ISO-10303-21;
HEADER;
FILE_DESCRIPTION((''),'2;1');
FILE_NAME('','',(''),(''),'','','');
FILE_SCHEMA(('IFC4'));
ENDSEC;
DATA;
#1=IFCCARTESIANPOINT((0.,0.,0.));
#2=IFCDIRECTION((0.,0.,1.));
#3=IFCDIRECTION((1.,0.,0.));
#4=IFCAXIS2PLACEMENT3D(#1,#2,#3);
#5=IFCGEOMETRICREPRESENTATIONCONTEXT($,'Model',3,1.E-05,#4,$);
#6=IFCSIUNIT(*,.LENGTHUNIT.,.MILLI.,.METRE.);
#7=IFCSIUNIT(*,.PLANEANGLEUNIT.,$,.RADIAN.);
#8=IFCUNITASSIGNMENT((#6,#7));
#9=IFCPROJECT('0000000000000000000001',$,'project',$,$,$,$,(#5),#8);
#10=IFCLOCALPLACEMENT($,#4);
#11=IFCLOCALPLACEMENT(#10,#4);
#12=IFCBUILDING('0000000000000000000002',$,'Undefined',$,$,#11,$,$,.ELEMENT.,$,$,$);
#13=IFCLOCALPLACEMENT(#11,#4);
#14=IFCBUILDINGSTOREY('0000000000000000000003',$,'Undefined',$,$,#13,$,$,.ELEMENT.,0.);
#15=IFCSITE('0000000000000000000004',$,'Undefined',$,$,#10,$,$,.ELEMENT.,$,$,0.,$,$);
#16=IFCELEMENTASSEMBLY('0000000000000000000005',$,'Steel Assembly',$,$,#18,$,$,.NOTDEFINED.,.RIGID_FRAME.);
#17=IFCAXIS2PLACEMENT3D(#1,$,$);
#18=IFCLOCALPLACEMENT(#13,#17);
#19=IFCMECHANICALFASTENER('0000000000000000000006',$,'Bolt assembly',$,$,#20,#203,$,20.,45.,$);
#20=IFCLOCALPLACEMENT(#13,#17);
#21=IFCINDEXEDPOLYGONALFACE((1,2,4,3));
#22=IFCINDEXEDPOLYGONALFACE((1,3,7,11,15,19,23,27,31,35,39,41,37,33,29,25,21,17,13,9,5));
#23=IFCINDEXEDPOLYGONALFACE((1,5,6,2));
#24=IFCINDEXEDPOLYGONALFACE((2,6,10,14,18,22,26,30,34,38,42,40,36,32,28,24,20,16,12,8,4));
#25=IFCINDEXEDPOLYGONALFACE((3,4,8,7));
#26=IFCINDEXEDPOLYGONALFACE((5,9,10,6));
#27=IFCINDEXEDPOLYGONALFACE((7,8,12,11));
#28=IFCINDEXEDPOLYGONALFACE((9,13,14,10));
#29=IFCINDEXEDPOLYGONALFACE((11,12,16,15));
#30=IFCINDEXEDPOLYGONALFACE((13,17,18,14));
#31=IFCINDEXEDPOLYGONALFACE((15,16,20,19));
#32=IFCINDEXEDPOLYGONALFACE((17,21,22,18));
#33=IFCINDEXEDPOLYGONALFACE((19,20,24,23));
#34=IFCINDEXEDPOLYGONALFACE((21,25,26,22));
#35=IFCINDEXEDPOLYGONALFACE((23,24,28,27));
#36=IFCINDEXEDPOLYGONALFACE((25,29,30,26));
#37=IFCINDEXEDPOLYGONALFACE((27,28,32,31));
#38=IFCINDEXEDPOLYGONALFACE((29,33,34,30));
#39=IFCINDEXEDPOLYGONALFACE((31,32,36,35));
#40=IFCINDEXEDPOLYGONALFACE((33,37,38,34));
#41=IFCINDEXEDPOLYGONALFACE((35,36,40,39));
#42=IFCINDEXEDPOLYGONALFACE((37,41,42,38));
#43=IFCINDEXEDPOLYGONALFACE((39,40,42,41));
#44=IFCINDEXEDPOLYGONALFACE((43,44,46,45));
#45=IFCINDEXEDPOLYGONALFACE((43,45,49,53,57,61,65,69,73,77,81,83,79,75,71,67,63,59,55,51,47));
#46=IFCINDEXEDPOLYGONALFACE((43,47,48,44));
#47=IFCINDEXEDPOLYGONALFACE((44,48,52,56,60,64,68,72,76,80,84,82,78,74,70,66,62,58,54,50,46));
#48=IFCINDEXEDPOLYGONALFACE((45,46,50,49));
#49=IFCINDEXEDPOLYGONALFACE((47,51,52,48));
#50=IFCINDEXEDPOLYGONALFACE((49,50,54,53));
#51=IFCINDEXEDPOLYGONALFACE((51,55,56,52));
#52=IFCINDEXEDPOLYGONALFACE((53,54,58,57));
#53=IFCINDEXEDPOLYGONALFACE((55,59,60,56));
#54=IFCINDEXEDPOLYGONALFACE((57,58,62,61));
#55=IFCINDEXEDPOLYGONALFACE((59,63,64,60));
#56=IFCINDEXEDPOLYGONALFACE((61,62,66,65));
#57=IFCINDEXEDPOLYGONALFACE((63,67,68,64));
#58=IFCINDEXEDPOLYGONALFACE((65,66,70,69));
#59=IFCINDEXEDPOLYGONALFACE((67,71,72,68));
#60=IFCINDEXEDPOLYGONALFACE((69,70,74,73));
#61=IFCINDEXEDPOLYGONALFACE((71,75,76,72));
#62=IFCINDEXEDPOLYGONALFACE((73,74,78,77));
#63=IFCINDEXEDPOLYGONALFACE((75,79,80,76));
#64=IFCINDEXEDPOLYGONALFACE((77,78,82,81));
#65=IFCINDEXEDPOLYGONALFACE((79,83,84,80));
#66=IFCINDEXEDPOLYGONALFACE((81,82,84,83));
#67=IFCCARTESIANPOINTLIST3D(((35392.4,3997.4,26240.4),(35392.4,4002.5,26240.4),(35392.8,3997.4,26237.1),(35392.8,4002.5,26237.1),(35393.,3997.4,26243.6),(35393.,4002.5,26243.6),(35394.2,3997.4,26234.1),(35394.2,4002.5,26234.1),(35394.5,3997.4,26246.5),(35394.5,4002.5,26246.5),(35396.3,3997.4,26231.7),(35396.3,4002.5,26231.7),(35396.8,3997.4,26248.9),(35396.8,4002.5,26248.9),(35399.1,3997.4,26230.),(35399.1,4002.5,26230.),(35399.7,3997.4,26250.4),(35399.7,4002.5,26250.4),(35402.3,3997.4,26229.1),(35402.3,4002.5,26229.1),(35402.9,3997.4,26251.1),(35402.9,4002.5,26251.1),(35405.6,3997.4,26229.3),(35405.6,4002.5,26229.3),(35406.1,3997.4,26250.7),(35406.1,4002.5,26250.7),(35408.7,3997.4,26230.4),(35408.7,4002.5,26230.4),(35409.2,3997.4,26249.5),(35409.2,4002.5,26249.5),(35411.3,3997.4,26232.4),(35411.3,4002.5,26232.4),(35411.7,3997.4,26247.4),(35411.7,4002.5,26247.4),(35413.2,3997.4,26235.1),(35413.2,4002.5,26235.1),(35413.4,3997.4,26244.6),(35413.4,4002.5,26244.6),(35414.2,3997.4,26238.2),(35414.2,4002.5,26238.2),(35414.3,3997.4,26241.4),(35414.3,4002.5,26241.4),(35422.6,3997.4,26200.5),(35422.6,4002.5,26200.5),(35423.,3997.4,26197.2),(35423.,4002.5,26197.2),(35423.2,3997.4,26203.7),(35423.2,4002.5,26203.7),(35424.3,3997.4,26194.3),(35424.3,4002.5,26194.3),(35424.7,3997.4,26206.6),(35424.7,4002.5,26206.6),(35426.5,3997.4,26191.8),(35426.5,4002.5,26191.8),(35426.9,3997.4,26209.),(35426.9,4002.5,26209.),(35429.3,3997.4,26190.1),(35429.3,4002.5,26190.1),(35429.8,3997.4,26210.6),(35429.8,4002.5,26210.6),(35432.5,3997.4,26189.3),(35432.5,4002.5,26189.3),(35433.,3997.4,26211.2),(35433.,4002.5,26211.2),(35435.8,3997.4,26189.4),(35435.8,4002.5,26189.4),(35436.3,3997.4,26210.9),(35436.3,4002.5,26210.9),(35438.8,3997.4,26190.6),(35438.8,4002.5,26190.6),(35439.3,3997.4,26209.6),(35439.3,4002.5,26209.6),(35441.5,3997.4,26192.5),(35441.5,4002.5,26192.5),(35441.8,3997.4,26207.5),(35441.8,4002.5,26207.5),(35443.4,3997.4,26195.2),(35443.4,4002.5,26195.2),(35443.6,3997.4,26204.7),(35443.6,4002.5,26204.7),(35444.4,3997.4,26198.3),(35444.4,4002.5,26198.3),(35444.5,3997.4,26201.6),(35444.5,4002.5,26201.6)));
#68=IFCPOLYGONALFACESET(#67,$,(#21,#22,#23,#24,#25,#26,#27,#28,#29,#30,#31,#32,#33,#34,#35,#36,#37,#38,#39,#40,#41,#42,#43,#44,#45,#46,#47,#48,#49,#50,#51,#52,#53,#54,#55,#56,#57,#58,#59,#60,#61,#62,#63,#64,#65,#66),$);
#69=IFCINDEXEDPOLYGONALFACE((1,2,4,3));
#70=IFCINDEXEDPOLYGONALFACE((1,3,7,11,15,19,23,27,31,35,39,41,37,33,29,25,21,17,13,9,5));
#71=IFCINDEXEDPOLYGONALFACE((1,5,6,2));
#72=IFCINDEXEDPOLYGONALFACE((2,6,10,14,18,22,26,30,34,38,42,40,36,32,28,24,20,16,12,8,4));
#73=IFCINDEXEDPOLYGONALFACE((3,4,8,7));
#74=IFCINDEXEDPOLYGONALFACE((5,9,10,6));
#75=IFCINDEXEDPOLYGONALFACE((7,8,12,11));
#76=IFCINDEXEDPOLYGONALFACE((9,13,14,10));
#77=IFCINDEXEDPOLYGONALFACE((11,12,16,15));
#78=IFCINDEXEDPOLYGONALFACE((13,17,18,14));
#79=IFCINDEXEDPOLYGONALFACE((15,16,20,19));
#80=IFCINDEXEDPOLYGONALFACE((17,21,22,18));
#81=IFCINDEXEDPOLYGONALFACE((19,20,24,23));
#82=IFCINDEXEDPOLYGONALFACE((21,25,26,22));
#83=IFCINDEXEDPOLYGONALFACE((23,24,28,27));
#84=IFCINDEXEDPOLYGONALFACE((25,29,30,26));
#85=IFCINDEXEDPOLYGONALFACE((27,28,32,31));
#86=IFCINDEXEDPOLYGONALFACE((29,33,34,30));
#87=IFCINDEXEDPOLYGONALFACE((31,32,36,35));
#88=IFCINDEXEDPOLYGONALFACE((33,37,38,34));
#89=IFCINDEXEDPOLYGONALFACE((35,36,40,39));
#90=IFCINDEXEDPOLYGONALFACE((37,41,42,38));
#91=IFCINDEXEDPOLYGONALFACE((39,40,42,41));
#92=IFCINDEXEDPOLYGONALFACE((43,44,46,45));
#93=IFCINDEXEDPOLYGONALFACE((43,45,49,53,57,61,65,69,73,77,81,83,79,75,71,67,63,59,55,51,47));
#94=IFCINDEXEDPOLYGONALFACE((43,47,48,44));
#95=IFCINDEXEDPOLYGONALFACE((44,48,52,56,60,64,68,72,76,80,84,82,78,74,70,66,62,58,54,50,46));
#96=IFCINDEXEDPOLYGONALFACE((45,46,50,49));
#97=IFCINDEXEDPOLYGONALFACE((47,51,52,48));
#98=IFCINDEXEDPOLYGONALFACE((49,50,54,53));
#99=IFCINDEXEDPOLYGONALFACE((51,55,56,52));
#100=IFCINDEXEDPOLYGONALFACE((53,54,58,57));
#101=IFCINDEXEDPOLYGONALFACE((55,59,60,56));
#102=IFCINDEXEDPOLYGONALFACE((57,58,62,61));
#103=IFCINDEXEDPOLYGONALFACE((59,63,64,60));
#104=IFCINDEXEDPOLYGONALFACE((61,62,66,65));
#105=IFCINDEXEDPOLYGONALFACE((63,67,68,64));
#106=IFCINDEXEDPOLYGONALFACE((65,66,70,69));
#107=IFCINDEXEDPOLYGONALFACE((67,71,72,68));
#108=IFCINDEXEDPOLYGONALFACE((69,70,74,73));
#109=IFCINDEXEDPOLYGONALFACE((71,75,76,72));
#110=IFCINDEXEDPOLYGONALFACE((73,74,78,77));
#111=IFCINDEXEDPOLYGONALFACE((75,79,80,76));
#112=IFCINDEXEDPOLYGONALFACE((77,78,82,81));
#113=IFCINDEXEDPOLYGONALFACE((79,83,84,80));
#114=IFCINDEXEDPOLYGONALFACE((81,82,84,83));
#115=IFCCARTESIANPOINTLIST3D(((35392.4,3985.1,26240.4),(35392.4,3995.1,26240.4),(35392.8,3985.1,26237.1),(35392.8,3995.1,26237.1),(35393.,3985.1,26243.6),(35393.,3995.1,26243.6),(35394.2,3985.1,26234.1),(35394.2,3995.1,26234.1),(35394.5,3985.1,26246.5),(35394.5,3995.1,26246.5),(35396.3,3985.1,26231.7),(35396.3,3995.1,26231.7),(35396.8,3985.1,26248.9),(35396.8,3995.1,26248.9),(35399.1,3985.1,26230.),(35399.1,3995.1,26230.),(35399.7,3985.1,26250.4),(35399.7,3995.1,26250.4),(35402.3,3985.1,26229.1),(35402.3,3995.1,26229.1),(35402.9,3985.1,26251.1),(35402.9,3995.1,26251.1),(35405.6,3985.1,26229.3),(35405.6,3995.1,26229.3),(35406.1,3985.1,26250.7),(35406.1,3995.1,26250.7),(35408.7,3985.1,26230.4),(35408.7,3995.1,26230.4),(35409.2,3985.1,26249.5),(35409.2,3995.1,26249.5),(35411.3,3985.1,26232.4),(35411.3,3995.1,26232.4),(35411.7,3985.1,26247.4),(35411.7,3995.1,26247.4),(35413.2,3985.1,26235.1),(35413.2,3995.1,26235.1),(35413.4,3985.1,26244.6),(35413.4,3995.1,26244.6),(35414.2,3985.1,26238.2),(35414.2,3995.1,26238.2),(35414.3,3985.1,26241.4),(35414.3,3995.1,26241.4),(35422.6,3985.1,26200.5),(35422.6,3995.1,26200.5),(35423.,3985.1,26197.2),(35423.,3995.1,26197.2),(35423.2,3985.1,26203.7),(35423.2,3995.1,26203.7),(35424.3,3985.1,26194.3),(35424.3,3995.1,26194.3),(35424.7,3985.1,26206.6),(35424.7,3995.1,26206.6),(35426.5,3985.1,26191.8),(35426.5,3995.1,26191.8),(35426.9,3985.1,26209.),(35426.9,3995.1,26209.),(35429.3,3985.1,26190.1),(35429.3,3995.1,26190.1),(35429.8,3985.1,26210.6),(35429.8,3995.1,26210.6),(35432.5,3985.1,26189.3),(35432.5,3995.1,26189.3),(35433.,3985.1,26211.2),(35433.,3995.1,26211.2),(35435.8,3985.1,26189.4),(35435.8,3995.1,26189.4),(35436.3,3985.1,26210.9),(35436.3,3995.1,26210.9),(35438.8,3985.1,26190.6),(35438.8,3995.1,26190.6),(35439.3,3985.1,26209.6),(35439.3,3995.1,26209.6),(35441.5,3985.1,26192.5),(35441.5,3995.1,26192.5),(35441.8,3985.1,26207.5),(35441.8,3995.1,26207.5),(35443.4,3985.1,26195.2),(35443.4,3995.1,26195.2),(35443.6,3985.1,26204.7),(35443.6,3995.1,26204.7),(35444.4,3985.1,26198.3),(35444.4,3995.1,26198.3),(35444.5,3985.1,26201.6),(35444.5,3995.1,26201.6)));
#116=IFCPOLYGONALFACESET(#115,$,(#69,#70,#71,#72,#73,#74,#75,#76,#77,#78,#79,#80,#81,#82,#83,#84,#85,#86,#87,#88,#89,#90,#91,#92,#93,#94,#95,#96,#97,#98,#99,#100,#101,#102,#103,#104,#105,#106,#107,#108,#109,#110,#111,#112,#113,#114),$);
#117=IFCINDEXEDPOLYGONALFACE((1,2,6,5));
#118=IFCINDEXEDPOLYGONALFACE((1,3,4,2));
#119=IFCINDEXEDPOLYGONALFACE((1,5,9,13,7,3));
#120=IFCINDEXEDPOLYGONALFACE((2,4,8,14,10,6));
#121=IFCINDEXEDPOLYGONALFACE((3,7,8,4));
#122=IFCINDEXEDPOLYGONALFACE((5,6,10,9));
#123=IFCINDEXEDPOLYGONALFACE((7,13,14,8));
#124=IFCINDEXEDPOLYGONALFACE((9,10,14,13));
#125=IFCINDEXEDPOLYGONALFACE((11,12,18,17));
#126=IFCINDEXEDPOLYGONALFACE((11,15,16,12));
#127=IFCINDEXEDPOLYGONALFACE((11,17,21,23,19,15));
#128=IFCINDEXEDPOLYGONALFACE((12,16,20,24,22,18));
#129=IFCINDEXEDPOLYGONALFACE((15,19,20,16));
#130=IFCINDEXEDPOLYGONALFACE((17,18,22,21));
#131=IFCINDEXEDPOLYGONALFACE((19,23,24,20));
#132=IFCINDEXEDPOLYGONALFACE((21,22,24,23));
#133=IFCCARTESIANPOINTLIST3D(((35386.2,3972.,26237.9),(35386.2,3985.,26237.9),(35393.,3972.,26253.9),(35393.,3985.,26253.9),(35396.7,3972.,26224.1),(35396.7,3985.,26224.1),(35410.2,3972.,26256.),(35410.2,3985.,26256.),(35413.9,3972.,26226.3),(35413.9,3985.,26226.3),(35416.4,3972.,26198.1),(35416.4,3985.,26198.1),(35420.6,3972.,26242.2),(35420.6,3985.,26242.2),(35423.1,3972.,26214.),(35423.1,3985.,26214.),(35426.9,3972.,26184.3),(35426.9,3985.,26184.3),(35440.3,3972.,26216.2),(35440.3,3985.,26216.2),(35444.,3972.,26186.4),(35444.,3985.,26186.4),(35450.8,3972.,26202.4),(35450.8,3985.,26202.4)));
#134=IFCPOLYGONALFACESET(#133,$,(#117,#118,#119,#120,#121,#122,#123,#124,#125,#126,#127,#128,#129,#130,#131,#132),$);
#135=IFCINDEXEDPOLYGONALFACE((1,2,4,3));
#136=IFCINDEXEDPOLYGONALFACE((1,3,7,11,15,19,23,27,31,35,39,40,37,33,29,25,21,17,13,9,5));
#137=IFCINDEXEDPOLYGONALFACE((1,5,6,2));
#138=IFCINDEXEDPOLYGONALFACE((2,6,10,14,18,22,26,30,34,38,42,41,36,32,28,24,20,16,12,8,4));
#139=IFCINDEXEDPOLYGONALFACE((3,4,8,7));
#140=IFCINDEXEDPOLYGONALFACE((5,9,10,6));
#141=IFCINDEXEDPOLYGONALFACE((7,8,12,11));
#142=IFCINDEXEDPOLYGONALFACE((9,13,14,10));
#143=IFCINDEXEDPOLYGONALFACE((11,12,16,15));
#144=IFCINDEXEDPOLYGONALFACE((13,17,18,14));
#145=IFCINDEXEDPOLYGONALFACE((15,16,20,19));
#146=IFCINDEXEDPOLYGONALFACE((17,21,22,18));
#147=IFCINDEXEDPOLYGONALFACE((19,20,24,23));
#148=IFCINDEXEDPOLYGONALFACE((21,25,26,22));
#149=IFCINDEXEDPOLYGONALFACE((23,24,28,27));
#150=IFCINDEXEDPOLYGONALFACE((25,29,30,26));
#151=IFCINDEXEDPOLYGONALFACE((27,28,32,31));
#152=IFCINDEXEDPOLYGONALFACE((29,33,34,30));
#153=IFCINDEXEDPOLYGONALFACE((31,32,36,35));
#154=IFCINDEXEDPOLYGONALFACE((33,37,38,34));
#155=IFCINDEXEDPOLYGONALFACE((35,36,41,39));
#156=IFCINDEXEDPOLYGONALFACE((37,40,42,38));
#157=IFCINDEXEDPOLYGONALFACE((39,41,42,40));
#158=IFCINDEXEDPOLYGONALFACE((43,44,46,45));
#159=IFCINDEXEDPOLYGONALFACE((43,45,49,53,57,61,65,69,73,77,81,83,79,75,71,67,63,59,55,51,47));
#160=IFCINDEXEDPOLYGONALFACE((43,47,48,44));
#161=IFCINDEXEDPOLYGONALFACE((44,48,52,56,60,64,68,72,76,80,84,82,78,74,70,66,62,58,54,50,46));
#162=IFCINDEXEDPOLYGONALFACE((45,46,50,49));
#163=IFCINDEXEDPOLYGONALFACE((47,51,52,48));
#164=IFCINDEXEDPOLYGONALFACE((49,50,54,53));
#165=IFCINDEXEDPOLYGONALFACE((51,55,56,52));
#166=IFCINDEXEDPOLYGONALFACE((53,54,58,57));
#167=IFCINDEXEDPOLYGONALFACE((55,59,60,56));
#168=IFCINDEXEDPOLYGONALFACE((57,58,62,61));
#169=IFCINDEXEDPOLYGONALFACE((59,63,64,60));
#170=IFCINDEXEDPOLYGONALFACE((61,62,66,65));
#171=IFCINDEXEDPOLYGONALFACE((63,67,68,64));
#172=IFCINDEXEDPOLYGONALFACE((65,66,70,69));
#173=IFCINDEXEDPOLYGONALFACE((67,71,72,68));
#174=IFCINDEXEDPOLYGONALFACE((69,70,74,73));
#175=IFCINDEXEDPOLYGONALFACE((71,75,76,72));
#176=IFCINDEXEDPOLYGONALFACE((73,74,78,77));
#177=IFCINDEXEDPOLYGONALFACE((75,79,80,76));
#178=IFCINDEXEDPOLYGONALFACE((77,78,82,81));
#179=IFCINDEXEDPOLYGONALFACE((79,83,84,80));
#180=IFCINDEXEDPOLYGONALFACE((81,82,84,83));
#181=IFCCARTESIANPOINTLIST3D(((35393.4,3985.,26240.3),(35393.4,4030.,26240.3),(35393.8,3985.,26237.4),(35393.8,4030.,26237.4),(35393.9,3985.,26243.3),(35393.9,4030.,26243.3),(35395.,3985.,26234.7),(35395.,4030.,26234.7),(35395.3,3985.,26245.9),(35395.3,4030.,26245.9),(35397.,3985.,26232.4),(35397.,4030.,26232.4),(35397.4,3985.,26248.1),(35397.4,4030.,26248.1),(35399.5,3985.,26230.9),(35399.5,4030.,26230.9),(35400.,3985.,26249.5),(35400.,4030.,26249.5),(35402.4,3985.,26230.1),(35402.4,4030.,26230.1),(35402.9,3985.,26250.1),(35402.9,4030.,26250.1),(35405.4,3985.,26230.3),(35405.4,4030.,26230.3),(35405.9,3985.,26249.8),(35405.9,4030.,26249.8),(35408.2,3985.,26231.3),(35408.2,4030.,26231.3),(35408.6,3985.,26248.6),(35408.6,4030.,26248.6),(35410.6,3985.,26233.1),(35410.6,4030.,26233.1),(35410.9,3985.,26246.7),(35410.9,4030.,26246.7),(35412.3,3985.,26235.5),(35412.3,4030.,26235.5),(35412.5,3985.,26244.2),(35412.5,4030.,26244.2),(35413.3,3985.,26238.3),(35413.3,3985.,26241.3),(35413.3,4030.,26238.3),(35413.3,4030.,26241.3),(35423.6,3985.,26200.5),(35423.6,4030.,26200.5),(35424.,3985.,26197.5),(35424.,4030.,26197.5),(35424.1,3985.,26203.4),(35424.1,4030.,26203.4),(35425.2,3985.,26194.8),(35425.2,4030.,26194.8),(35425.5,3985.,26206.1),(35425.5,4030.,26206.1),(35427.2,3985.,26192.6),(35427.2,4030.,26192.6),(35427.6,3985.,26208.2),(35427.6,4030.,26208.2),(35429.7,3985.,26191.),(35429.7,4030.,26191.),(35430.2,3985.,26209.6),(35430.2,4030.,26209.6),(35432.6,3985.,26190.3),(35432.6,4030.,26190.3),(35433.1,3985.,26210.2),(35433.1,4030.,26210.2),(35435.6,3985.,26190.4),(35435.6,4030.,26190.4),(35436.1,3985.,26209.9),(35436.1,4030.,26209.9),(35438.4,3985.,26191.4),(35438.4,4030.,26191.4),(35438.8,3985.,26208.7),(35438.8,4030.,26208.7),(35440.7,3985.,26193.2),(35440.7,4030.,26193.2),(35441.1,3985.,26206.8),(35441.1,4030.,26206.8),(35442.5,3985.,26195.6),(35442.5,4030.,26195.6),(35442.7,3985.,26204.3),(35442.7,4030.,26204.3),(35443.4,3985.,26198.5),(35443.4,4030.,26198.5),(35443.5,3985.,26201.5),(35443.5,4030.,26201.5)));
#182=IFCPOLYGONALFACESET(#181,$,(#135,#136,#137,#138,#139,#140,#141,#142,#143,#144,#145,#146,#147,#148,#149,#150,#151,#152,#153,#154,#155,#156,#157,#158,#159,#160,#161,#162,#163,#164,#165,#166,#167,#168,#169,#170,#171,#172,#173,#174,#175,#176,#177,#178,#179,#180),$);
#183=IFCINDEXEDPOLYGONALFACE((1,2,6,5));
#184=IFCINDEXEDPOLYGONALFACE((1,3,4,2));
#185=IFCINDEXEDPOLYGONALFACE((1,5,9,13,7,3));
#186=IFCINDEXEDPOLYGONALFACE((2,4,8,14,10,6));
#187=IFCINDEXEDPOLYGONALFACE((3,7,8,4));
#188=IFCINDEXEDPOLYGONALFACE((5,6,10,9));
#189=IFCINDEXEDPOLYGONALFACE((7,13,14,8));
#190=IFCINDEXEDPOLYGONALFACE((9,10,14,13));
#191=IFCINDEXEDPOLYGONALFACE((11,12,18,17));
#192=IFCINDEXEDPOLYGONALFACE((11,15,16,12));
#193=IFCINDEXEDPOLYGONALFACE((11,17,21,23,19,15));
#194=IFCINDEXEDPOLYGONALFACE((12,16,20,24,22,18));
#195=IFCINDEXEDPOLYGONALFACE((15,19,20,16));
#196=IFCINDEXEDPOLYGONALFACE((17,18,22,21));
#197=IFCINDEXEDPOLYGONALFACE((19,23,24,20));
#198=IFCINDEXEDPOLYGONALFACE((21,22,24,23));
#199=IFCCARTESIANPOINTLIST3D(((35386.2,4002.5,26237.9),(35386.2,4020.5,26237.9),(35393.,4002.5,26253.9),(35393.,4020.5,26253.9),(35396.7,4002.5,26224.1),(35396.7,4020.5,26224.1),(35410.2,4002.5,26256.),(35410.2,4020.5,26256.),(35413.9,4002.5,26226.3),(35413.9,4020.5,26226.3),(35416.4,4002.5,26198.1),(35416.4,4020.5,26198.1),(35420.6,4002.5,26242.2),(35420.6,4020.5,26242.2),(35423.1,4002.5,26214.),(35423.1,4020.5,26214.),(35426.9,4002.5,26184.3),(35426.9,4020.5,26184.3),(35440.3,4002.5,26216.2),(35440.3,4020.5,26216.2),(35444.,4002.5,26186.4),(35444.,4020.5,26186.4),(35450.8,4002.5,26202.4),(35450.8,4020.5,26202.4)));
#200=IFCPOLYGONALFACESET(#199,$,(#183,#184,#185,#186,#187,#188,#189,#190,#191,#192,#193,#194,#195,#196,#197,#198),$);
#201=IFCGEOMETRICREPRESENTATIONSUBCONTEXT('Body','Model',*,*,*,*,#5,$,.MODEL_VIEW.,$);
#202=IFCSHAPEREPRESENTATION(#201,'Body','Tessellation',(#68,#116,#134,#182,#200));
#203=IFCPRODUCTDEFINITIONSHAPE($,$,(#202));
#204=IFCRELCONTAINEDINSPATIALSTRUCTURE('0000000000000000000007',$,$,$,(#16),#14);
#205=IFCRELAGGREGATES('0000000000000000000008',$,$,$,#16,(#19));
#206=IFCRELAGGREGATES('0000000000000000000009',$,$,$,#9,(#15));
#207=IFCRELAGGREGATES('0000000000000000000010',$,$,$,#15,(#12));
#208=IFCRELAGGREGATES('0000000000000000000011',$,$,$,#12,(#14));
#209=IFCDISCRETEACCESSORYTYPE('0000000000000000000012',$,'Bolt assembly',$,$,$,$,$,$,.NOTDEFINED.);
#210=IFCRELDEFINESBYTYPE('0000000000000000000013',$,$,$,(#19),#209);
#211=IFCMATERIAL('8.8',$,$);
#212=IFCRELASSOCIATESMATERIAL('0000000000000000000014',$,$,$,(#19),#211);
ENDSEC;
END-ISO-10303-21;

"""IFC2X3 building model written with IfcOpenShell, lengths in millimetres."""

from ifc_helpers import new_model, si_unit, frame, origin_with_axes, origin_2d_with_axis, place, context, subcontext, project, spatial, polyline, circle, outline, extrude, source, transform, mapped, material, type_object, element, aggregate, save


model = new_model("IFC2X3")

# Units and contexts
model_context = context("Model", 3, precision=1e-05, world=origin_with_axes())
body_context = subcontext(model_context, "Body", "Model", "MODEL_VIEW")
ifc_project = project(units=[si_unit("LENGTHUNIT", "METRE", prefix="MILLI"), si_unit("PLANEANGLEUNIT", "RADIAN")], contexts=[model_context])

# Site, building, storey
site_placement = place(None, origin_with_axes())
site = spatial("IfcSite", under=ifc_project, at=site_placement, Name="Undefined", CompositionType="ELEMENT", RefElevation=0.0)
building_placement = place(site_placement, origin_with_axes())
building = spatial("IfcBuilding", under=site, at=building_placement, Name="Undefined", CompositionType="ELEMENT")
storey_placement = place(building_placement, origin_with_axes())
storey = spatial("IfcBuildingStorey", under=building, at=storey_placement, Name="Undefined", CompositionType="ELEMENT", Elevation=0.0)

# Element assembly
assembly_1_placement = place(storey_placement, origin_with_axes())
assembly_1 = element("IfcElementAssembly", 1, at=assembly_1_placement, inside=storey, Name="Steel Assembly", AssemblyPlace="NOTDEFINED", PredefinedType="RIGID_FRAME")

# Shared definitions
discrete_accessory_type_1 = type_object("IfcDiscreteAccessoryType", Name="Bolt assembly")
ifc_material_1 = material(Name="8.8")

# Mechanical fastener
shared_shape_1 = source(origin_with_axes(), body_context, "Body", "SweptSolid", [
    extrude(circle(Radius=11.0, at=origin_2d_with_axis()), frame((0.0, -2.6, 0.0), z_axis=(0.0, 1.0, 0.0), x_axis=(1.0, 0.0, 0.0)), (0.0, 0.0, 1.0), 5.1),
    extrude(circle(Radius=11.0, at=origin_2d_with_axis()), frame((0.0, -14.9, 0.0), z_axis=(0.0, 1.0, 0.0), x_axis=(1.0, 0.0, 0.0)), (0.0, 0.0, 1.0), 10.0),
    extrude(outline(polyline([(17.3, 0.0), (8.7, 15.0), (-8.7, 15.0), (-17.3, 0.0), (-8.7, -15.0), (8.7, -15.0), (17.3, 0.0)])), frame((0.0, -28.0, 0.0), z_axis=(0.0, 1.0, 0.0), x_axis=(1.0, 0.0, 0.0)), (0.0, 0.0, 1.0), 13.0),
    extrude(circle(Radius=10.0, at=origin_2d_with_axis()), frame((0.0, -15.0, 0.0), z_axis=(0.0, 1.0, 0.0), x_axis=(1.0, 0.0, 0.0)), (0.0, 0.0, 1.0), 45.0),
    extrude(outline(polyline([(17.3, 0.0), (8.7, 15.0), (-8.7, 15.0), (-17.3, 0.0), (-8.7, -15.0), (8.7, -15.0), (17.3, 0.0)])), frame((0.0, 2.5, 0.0), z_axis=(0.0, 1.0, 0.0), x_axis=(1.0, 0.0, 0.0)), (0.0, 0.0, 1.0), 18.0),
])
mechanical_fastener_1_placement = place(assembly_1_placement, frame((35433.6, 4000.0, 26200.2), z_axis=(-0.797403, 0.0, -0.603447), x_axis=(-0.603447, 0.0, 0.797403)))
mechanical_fastener_1 = element("IfcMechanicalFastener", 2, at=mechanical_fastener_1_placement, type_object=discrete_accessory_type_1, material=ifc_material_1, Name="Bolt assembly", NominalDiameter=20.0, NominalLength=45.0, context=body_context, shape_type="MappedRepresentation", body=[
    mapped(shared_shape_1, transform((0.0, 0.0, 0.0))),
    mapped(shared_shape_1, transform((50.0, 0.0, 0.0))),
])
aggregate(assembly_1, [mechanical_fastener_1])

save(model, "model.ifc")
